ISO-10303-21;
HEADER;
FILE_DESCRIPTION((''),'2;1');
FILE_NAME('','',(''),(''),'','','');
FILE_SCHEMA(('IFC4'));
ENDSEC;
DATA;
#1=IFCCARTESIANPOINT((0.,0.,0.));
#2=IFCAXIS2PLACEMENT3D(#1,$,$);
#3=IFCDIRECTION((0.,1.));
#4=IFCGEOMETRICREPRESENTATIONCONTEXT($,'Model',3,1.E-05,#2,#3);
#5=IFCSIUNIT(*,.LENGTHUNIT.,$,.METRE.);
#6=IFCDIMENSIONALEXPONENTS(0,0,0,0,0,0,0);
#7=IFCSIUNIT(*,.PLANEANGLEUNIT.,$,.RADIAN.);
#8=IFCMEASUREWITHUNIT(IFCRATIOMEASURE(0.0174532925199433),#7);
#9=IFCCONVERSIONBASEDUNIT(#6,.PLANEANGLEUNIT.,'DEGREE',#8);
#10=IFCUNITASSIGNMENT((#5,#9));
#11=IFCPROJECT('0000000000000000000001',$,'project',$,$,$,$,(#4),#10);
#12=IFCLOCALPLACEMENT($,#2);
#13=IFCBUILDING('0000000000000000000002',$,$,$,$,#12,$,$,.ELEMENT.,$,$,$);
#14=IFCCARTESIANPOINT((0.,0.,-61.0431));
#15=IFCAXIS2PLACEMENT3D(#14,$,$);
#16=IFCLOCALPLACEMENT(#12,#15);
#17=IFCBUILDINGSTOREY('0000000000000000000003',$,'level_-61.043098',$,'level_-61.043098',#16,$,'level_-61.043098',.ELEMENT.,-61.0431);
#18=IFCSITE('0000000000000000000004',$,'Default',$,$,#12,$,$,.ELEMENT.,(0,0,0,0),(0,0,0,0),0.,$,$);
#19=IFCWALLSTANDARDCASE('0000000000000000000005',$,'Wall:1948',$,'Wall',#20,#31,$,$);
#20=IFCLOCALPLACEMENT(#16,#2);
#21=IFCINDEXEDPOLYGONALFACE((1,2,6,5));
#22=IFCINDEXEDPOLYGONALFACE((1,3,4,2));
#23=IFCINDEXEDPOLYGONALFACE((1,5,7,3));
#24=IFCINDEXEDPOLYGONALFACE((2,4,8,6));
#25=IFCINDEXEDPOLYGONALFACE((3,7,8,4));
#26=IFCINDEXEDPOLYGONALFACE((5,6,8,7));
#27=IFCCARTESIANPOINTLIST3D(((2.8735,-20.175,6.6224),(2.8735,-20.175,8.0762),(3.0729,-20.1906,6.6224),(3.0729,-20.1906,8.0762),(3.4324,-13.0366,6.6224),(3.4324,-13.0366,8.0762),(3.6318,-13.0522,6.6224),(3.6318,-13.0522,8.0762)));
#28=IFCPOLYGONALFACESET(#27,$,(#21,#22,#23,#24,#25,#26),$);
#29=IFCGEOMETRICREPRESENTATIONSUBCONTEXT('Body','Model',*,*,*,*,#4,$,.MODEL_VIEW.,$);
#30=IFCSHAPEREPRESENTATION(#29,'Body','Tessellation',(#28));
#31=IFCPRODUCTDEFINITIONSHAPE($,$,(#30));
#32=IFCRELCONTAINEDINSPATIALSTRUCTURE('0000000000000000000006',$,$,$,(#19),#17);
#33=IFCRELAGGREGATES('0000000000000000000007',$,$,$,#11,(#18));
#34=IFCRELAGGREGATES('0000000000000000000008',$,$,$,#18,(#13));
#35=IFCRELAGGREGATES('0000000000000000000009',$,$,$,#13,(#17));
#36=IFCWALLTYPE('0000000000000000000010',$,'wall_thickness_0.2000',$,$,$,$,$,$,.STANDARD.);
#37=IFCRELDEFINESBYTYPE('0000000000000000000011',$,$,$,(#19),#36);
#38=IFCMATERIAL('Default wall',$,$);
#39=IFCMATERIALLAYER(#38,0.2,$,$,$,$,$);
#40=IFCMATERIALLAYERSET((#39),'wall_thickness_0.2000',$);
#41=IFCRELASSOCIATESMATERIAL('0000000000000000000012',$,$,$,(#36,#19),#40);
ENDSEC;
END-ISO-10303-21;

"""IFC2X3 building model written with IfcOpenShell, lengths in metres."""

from ifc_helpers import new_model, entity, si_unit, converted_unit, direction, frame, origin, place, context, subcontext, project, spatial, polyline, outline, extrude, material, layer, layer_set, layer_usage, type_object, element, save


model = new_model("IFC2X3")

# Units and contexts
model_context = context("Model", 3, precision=1e-05, world=origin(), true_north=direction((0.0, 1.0)))
body_context = subcontext(model_context, "Body", "Model", "MODEL_VIEW")
ifc_project = project(units=[si_unit("LENGTHUNIT", "METRE"), converted_unit("PLANEANGLEUNIT", "DEGREE", entity("IfcRatioMeasure", 0.0174532925199433), si_unit("PLANEANGLEUNIT", "RADIAN"), dimensions=[0, 0, 0, 0, 0, 0, 0])], contexts=[model_context])

# Site, building, storey
placement_1 = place(None, origin())
site = spatial("IfcSite", under=ifc_project, at=placement_1, Name="Default", CompositionType="ELEMENT", RefLatitude=(0, 0, 0, 0), RefLongitude=(0, 0, 0, 0), RefElevation=0.0)
building = spatial("IfcBuilding", under=site, at=placement_1, CompositionType="ELEMENT")
storey_placement = place(placement_1, frame((0.0, 0.0, -61.0431)))
storey = spatial("IfcBuildingStorey", under=building, at=storey_placement, Name="level_-61.043098", ObjectType="level_-61.043098", LongName="level_-61.043098", CompositionType="ELEMENT", Elevation=-61.0431)

# Shared definitions
ifc_material_1 = material(Name="Default wall")
ifc_layer = layer(ifc_material_1, 0.2)
ifc_layer_set = layer_set([ifc_layer], Name="wall_thickness_0.2000")
ifc_layer_usage = layer_usage(ifc_layer_set, "AXIS2", "POSITIVE", -0.1)
wall_type = type_object("IfcWallType", Name="wall_thickness_0.2000", PredefinedType="STANDARD", material=ifc_layer_set)

# Wall
placement_2 = place(placement_1, frame((0.0, 0.0, -54.4207)))
wall_1_placement = place(placement_2, frame((2.9732, -20.1828, 0.0), z_axis=(0.0, 0.0, 1.0), x_axis=(0.078053, 0.996949, 0.0)))
element("IfcWallStandardCase", 1, at=wall_1_placement, inside=storey, type_object=wall_type, material=ifc_layer_usage, Name="Wall:1948", ObjectType="Wall", context=body_context, shape_type="SweptSolid", body=[
    extrude(outline(polyline([(7.1602, -0.1), (7.1602, 0.1), (0.0, 0.1), (0.0, -0.1), (7.1602, -0.1)])), origin(), (0.0, 0.0, 1.0), 1.4538),
])

save(model, "model.ifc")
